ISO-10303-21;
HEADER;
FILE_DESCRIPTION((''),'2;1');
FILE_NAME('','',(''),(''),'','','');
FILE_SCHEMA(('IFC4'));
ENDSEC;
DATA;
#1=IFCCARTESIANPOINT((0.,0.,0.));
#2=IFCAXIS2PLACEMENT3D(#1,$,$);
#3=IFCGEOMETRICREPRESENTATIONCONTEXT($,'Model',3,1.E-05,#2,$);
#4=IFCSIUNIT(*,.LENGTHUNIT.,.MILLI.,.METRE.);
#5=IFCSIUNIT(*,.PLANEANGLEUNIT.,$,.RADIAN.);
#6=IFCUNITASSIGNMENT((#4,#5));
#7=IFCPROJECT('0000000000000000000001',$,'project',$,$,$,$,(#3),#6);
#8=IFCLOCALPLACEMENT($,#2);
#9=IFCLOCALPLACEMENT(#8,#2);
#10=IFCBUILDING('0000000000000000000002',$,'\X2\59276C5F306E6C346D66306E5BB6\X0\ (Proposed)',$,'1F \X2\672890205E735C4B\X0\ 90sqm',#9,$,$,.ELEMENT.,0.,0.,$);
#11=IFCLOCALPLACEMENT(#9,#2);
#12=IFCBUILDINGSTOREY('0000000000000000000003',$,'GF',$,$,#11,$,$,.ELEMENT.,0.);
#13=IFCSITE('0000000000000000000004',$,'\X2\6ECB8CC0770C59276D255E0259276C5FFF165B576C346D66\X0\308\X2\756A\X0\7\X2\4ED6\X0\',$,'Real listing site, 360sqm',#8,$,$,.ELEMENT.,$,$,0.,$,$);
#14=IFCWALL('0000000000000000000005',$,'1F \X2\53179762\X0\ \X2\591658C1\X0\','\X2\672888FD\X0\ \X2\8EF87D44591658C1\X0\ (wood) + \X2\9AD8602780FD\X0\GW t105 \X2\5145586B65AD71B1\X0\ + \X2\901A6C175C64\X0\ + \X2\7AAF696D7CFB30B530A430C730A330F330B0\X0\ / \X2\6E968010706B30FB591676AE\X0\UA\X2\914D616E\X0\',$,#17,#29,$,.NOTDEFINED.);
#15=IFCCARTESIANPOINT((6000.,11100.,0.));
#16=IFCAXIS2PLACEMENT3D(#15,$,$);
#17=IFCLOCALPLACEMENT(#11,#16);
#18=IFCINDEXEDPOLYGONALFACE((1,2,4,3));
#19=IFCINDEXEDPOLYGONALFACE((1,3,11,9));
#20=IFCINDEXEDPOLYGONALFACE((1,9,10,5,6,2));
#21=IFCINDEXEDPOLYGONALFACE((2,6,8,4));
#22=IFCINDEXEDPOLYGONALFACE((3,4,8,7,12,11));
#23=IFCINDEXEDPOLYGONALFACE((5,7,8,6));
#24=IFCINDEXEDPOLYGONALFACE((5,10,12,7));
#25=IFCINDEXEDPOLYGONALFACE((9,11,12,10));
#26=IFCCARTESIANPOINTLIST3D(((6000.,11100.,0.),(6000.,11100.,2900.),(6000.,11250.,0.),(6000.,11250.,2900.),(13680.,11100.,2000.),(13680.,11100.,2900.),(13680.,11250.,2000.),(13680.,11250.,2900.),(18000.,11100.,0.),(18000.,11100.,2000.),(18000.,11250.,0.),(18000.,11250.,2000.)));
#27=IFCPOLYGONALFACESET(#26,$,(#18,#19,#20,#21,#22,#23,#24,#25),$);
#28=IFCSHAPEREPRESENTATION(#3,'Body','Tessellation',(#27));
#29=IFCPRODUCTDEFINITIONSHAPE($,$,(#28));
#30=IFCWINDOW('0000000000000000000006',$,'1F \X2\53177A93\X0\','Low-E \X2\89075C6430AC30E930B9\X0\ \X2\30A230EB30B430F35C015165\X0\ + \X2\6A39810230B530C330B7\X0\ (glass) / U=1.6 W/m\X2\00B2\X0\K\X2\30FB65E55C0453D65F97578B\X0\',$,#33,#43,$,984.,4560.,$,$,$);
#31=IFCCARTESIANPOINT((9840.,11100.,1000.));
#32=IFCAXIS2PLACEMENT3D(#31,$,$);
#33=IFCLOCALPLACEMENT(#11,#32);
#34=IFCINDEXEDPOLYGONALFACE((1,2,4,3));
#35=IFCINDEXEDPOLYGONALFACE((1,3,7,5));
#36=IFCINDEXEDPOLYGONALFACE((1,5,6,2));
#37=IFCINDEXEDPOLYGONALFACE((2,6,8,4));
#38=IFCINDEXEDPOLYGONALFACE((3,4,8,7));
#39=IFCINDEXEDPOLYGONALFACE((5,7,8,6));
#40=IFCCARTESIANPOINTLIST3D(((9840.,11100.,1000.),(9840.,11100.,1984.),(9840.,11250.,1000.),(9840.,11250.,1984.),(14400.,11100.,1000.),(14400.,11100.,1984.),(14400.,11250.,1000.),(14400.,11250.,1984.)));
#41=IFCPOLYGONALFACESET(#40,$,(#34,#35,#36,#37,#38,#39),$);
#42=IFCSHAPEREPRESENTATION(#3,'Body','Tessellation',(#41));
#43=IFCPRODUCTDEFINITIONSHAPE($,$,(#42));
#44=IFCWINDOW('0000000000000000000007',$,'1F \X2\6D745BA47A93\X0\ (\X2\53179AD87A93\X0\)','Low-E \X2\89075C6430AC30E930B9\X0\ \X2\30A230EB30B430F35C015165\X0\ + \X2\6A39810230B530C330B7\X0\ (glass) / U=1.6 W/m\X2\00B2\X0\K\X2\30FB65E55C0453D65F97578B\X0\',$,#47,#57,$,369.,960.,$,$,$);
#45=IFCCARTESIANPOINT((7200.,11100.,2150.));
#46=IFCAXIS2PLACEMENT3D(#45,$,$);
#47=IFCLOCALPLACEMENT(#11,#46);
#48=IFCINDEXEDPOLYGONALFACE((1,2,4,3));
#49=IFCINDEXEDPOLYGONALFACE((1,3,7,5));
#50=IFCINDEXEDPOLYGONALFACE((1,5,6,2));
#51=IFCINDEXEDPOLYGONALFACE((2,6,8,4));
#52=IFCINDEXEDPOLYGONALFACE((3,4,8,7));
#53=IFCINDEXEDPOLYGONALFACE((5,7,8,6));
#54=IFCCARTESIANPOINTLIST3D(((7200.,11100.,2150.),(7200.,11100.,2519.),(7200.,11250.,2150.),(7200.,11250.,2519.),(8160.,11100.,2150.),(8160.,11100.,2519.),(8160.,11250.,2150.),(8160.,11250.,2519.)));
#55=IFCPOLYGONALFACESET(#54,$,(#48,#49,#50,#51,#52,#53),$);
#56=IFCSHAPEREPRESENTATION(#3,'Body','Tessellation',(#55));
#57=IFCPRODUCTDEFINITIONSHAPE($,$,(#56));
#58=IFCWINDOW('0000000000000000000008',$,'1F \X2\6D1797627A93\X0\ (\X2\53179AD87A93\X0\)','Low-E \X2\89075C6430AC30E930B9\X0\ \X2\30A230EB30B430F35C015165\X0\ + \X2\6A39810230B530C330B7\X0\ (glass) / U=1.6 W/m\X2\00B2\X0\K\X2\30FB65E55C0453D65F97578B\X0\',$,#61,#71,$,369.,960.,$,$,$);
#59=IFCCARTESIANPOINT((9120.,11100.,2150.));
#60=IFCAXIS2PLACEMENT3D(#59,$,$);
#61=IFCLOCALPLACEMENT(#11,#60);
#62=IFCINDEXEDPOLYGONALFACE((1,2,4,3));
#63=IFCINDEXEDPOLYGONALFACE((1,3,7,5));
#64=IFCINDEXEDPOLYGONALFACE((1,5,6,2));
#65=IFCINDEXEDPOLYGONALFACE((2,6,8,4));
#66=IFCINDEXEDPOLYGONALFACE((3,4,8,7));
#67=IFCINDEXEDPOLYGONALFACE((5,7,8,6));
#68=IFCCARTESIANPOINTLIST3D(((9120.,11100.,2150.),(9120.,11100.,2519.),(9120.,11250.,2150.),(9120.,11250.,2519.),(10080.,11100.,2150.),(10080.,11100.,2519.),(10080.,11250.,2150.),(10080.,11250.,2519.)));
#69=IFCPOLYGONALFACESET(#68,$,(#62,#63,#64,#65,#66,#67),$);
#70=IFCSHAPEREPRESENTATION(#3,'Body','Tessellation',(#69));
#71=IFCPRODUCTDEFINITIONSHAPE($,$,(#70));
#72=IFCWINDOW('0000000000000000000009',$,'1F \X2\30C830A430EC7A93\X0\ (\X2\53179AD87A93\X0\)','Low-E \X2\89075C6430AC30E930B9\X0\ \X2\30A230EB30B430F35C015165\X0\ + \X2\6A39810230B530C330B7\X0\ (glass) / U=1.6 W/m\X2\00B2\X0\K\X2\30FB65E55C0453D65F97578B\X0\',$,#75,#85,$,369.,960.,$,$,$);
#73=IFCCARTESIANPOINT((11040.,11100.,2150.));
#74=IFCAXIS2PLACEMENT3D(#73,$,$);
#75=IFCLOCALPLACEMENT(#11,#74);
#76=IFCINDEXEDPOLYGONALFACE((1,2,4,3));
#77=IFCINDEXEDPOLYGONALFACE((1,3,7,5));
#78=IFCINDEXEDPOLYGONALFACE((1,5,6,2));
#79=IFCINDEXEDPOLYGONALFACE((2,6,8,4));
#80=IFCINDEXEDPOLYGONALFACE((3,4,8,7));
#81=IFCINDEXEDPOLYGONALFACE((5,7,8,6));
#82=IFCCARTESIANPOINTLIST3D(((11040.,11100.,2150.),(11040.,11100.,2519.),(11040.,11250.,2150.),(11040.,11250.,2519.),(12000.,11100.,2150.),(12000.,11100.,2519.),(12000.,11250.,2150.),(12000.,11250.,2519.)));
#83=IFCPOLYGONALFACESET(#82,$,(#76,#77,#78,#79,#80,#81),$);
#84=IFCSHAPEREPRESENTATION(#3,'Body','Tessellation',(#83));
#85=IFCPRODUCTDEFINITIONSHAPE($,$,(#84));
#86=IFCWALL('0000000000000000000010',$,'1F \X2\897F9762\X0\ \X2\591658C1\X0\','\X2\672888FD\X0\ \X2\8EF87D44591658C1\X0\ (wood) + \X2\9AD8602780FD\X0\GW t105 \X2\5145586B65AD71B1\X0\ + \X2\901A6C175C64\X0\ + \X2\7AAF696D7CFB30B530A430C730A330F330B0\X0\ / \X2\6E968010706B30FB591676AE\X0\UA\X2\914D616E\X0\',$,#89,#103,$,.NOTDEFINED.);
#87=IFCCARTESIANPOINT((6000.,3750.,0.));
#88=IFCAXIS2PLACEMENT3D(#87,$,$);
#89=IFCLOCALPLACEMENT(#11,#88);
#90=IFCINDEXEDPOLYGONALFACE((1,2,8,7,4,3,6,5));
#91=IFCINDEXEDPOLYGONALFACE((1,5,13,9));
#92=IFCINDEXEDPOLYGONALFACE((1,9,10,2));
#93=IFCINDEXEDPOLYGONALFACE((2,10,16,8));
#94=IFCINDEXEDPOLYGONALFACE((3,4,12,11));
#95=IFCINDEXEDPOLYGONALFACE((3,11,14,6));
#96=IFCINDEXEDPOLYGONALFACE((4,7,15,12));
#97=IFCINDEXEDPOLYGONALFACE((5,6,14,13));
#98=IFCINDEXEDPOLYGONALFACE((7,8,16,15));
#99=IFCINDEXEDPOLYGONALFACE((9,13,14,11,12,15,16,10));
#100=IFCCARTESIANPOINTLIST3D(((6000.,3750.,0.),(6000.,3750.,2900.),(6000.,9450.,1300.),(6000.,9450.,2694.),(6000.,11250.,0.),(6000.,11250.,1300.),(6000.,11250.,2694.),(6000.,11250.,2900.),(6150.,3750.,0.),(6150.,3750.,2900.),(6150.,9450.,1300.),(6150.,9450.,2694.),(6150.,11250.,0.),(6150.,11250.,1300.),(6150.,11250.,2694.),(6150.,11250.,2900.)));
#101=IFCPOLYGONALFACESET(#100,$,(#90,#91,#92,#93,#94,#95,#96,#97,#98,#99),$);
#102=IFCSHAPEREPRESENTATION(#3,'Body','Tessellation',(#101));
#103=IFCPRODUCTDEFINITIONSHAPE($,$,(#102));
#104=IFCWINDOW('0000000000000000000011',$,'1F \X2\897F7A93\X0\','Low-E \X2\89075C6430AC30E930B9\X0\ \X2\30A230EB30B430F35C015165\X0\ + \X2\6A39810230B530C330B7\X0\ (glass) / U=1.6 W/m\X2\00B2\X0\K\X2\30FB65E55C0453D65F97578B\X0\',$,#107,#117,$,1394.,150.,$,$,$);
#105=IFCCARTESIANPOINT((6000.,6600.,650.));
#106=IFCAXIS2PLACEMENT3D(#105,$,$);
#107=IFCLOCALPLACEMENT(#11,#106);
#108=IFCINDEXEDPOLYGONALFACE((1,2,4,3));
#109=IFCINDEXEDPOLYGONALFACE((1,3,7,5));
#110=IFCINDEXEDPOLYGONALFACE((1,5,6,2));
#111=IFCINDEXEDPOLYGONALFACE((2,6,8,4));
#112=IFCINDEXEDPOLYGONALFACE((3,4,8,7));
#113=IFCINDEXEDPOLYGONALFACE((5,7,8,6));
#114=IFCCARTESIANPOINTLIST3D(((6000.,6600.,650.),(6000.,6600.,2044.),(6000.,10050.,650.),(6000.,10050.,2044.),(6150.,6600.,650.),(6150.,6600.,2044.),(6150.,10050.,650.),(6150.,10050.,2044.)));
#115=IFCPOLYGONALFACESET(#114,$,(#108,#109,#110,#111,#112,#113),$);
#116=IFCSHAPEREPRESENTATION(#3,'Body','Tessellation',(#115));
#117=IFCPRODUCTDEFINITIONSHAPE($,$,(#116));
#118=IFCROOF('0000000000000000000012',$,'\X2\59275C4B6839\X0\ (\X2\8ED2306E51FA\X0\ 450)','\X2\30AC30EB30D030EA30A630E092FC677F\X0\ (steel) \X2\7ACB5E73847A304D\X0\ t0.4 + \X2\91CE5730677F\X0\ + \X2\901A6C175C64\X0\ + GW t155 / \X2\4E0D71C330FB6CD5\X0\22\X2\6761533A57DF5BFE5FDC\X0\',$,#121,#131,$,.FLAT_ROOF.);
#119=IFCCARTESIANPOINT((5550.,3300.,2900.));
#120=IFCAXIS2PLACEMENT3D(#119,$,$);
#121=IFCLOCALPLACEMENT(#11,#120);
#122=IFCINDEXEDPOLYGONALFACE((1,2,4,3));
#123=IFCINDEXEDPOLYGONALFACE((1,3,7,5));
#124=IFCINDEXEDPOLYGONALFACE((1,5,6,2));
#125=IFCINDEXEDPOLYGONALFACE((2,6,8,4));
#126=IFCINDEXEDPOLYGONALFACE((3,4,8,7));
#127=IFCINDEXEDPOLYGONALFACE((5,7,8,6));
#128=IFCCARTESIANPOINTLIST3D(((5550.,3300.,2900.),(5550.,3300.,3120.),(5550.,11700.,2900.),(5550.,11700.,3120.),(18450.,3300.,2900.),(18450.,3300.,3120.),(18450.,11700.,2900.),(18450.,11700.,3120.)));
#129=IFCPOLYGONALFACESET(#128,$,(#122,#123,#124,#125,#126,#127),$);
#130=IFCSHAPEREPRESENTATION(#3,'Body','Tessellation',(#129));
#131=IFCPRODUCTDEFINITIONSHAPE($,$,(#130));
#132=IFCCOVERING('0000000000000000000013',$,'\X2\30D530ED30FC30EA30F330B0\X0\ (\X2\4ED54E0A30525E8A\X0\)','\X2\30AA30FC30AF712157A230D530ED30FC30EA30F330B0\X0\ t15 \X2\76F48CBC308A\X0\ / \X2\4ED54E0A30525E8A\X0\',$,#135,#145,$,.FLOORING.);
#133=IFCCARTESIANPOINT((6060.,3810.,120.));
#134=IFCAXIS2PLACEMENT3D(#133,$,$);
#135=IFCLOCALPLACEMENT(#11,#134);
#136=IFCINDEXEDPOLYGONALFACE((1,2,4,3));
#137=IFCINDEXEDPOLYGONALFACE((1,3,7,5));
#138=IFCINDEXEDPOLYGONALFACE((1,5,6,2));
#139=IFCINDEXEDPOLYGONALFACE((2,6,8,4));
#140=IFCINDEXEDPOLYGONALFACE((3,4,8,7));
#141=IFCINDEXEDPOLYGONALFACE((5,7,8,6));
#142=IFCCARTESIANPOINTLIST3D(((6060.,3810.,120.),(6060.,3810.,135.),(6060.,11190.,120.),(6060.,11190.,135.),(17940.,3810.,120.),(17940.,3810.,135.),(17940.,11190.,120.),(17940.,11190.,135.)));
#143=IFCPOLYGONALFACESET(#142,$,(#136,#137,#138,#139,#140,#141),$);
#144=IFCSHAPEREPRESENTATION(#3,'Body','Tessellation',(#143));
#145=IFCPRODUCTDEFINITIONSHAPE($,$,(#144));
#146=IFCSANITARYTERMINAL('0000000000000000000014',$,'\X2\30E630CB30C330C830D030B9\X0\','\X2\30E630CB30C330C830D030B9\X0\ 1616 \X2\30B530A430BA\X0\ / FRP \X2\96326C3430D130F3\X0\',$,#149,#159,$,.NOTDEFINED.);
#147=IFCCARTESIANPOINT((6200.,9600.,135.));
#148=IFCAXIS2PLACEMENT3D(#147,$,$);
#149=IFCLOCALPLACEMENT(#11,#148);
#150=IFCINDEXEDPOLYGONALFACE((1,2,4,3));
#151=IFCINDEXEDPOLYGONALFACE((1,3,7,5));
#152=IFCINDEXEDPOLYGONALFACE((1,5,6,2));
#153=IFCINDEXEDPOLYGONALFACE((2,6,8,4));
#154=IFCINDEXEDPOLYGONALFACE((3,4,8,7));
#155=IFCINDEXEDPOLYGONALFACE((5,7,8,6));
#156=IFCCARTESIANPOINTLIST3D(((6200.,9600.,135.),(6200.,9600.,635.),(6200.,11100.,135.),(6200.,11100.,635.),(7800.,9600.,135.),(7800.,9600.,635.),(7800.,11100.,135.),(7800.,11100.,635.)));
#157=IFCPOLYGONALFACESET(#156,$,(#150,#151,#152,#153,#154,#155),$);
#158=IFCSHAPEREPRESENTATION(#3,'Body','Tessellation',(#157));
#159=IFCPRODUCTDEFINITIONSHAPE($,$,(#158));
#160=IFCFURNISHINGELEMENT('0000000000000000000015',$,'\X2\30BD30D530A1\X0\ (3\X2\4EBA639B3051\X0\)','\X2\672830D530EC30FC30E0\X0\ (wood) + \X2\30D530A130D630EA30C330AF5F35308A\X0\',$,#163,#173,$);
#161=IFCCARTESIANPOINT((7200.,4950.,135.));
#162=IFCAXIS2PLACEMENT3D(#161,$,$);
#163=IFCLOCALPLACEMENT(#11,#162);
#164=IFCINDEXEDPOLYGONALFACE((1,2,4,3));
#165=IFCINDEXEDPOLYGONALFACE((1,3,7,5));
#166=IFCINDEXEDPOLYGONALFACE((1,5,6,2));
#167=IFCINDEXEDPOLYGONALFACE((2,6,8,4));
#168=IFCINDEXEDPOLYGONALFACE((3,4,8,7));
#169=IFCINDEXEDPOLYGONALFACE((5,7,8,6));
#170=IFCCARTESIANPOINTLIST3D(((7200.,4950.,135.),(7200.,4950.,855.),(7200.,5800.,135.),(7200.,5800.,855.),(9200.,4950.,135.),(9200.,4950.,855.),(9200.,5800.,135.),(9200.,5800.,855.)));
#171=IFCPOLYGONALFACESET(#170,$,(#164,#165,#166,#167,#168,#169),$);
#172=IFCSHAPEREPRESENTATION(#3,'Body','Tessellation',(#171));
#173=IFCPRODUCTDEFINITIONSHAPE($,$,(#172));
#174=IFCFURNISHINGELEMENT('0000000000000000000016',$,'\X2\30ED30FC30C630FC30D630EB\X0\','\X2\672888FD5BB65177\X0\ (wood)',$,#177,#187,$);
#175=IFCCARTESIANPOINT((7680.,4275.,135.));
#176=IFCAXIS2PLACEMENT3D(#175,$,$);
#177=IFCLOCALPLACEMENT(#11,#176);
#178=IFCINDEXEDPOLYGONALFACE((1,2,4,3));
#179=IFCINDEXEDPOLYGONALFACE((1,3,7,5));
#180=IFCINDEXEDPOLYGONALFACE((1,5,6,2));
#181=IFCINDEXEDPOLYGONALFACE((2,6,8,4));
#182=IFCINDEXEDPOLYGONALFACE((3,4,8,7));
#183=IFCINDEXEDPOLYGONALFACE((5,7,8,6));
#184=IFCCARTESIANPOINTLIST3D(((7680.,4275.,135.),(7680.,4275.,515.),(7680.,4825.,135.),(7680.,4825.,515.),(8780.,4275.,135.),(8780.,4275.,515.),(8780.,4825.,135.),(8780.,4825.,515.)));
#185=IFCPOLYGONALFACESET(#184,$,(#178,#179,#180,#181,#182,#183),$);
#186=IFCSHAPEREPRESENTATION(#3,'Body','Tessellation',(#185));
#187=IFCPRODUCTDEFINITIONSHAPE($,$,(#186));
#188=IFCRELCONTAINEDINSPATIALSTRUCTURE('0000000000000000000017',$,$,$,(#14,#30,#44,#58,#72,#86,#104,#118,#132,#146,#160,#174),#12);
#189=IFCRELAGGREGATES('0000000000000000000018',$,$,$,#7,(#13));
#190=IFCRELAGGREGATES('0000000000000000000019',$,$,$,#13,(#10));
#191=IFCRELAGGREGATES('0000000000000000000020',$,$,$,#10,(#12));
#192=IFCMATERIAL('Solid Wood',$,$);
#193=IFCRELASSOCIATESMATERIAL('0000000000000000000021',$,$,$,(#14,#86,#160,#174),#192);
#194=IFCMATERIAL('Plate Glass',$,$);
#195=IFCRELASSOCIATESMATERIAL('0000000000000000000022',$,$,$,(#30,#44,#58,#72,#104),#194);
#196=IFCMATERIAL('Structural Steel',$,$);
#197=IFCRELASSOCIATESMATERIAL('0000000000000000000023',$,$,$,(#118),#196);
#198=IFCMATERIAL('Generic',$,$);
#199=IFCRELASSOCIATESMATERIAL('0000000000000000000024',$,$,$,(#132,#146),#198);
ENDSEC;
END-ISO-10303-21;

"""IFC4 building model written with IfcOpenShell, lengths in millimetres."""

from ifc_helpers import new_model, si_unit, frame, frame_2d, origin, place, context, project, spatial, rectangle, extrude, material, element, fill, save


model = new_model("IFC4")

# Units and contexts
model_context = context("Model", 3, precision=1e-05, world=origin())
ifc_project = project(units=[si_unit("LENGTHUNIT", "METRE", prefix="MILLI"), si_unit("PLANEANGLEUNIT", "RADIAN")], contexts=[model_context])

# Site, building, storey
site_placement = place(None, origin())
site = spatial("IfcSite", under=ifc_project, at=site_placement, Name="滋賀県大津市大江６字水浦308番7他", ObjectType="Real listing site, 360sqm", CompositionType="ELEMENT", RefElevation=0.0)
building_placement = place(site_placement, origin())
building = spatial("IfcBuilding", under=site, at=building_placement, Name="大江の水浦の家 (Proposed)", ObjectType="1F 木造平屋 90sqm", CompositionType="ELEMENT", ElevationOfRefHeight=0.0, ElevationOfTerrain=0.0)
storey_placement = place(building_placement, origin())
storey = spatial("IfcBuildingStorey", under=building, at=storey_placement, Name="GF", CompositionType="ELEMENT", Elevation=0.0)

# Shared definitions
ifc_material_1 = material(Name="Solid Wood")

# Shared definitions
ifc_material_2 = material(Name="Plate Glass")

# Wall, openings, windows
wall_1_placement = place(storey_placement, frame((6000.0, 11100.0, 0.0)))
wall_1 = element("IfcWall", 1, at=wall_1_placement, inside=storey, material=ifc_material_1, Name="1F 北面 外壁", Description="木製 軸組外壁 (wood) + 高性能GW t105 充填断熱 + 通気層 + 窯業系サイディング / 準耐火・外皮UA配慮", PredefinedType="NOTDEFINED", context=model_context, shape_type="SweptSolid", body=[
    extrude(rectangle(XDim=12000.0, YDim=150.0, at=frame_2d((6000.0, 75.0))), frame((6000.0, 11100.0, 0.0)), (0.0, 0.0, 1.0), 2900.0),
])
opening_1_placement = place(storey_placement, frame((9840.0, 11100.0, 1000.0)))
opening_1 = element("IfcOpeningElement", 2, at=opening_1_placement, cuts=wall_1, PredefinedType="NOTDEFINED", context=model_context, shape_type="SweptSolid", body=[
    extrude(rectangle(XDim=4560.0, YDim=150.0, at=frame_2d((2280.0, 75.0))), frame((9840.0, 11100.0, 1000.0)), (0.0, 0.0, 1.0), 984.0),
])
opening_2_placement = place(storey_placement, frame((7200.0, 11100.0, 2150.0)))
opening_2 = element("IfcOpeningElement", 3, at=opening_2_placement, cuts=wall_1, PredefinedType="NOTDEFINED", context=model_context, shape_type="SweptSolid", body=[
    extrude(rectangle(XDim=960.0, YDim=150.0, at=frame_2d((480.0, 75.0))), frame((7200.0, 11100.0, 2150.0)), (0.0, 0.0, 1.0), 369.0),
])
opening_3_placement = place(storey_placement, frame((9120.0, 11100.0, 2150.0)))
opening_3 = element("IfcOpeningElement", 4, at=opening_3_placement, cuts=wall_1, PredefinedType="NOTDEFINED", context=model_context, shape_type="SweptSolid", body=[
    extrude(rectangle(XDim=960.0, YDim=150.0, at=frame_2d((480.0, 75.0))), frame((9120.0, 11100.0, 2150.0)), (0.0, 0.0, 1.0), 369.0),
])
opening_4_placement = place(storey_placement, frame((11040.0, 11100.0, 2150.0)))
opening_4 = element("IfcOpeningElement", 5, at=opening_4_placement, cuts=wall_1, PredefinedType="NOTDEFINED", context=model_context, shape_type="SweptSolid", body=[
    extrude(rectangle(XDim=960.0, YDim=150.0, at=frame_2d((480.0, 75.0))), frame((11040.0, 11100.0, 2150.0)), (0.0, 0.0, 1.0), 369.0),
])
window_1_placement = place(storey_placement, frame((9840.0, 11100.0, 1000.0)))
window_1 = element("IfcWindow", 6, at=window_1_placement, inside=storey, material=ifc_material_2, Name="1F 北窓", Description="Low-E 複層ガラス アルゴン封入 + 樹脂サッシ (glass) / U=1.6 W/m²K・日射取得型", OverallHeight=984.0, OverallWidth=4560.0, context=model_context, shape_type="SweptSolid", body=[
    extrude(rectangle(XDim=4560.0, YDim=150.0, at=frame_2d((2280.0, 75.0))), frame((9840.0, 11100.0, 1000.0)), (0.0, 0.0, 1.0), 984.0),
])
fill(opening_1, window_1)
window_2_placement = place(storey_placement, frame((7200.0, 11100.0, 2150.0)))
window_2 = element("IfcWindow", 7, at=window_2_placement, inside=storey, material=ifc_material_2, Name="1F 浴室窓 (北高窓)", Description="Low-E 複層ガラス アルゴン封入 + 樹脂サッシ (glass) / U=1.6 W/m²K・日射取得型", OverallHeight=369.0, OverallWidth=960.0, context=model_context, shape_type="SweptSolid", body=[
    extrude(rectangle(XDim=960.0, YDim=150.0, at=frame_2d((480.0, 75.0))), frame((7200.0, 11100.0, 2150.0)), (0.0, 0.0, 1.0), 369.0),
])
fill(opening_2, window_2)
window_3_placement = place(storey_placement, frame((9120.0, 11100.0, 2150.0)))
window_3 = element("IfcWindow", 8, at=window_3_placement, inside=storey, material=ifc_material_2, Name="1F 洗面窓 (北高窓)", Description="Low-E 複層ガラス アルゴン封入 + 樹脂サッシ (glass) / U=1.6 W/m²K・日射取得型", OverallHeight=369.0, OverallWidth=960.0, context=model_context, shape_type="SweptSolid", body=[
    extrude(rectangle(XDim=960.0, YDim=150.0, at=frame_2d((480.0, 75.0))), frame((9120.0, 11100.0, 2150.0)), (0.0, 0.0, 1.0), 369.0),
])
fill(opening_3, window_3)
window_4_placement = place(storey_placement, frame((11040.0, 11100.0, 2150.0)))
window_4 = element("IfcWindow", 9, at=window_4_placement, inside=storey, material=ifc_material_2, Name="1F トイレ窓 (北高窓)", Description="Low-E 複層ガラス アルゴン封入 + 樹脂サッシ (glass) / U=1.6 W/m²K・日射取得型", OverallHeight=369.0, OverallWidth=960.0, context=model_context, shape_type="SweptSolid", body=[
    extrude(rectangle(XDim=960.0, YDim=150.0, at=frame_2d((480.0, 75.0))), frame((11040.0, 11100.0, 2150.0)), (0.0, 0.0, 1.0), 369.0),
])
fill(opening_4, window_4)

# Wall, opening, window
wall_2_placement = place(storey_placement, frame((6000.0, 3750.0, 0.0)))
wall_2 = element("IfcWall", 10, at=wall_2_placement, inside=storey, material=ifc_material_1, Name="1F 西面 外壁", Description="木製 軸組外壁 (wood) + 高性能GW t105 充填断熱 + 通気層 + 窯業系サイディング / 準耐火・外皮UA配慮", PredefinedType="NOTDEFINED", context=model_context, shape_type="SweptSolid", body=[
    extrude(rectangle(XDim=150.0, YDim=7500.0, at=frame_2d((75.0, 3750.0))), frame((6000.0, 3750.0, 0.0)), (0.0, 0.0, 1.0), 2900.0),
])
opening_5_placement = place(storey_placement, frame((6000.0, 6600.0, 650.0)))
opening_5 = element("IfcOpeningElement", 11, at=opening_5_placement, cuts=wall_2, PredefinedType="NOTDEFINED", context=model_context, shape_type="SweptSolid", body=[
    extrude(rectangle(XDim=150.0, YDim=3450.0, at=frame_2d((75.0, 1725.0))), frame((6000.0, 6600.0, 650.0)), (0.0, 0.0, 1.0), 1394.0),
])
window_5_placement = place(storey_placement, frame((6000.0, 6600.0, 650.0)))
window_5 = element("IfcWindow", 12, at=window_5_placement, inside=storey, material=ifc_material_2, Name="1F 西窓", Description="Low-E 複層ガラス アルゴン封入 + 樹脂サッシ (glass) / U=1.6 W/m²K・日射取得型", OverallHeight=1394.0, OverallWidth=150.0, context=model_context, shape_type="SweptSolid", body=[
    extrude(rectangle(XDim=150.0, YDim=3450.0, at=frame_2d((75.0, 1725.0))), frame((6000.0, 6600.0, 650.0)), (0.0, 0.0, 1.0), 1394.0),
])
fill(opening_5, window_5)

# Roof
ifc_material_3 = material(Name="Structural Steel")
roof_placement = place(storey_placement, frame((5550.0, 3300.0, 2900.0)))
element("IfcRoof", 13, at=roof_placement, inside=storey, material=ifc_material_3, Name="大屋根 (軒の出 450)", Description="ガルバリウム鋼板 (steel) 立平葺き t0.4 + 野地板 + 通気層 + GW t155 / 不燃・法22条区域対応", PredefinedType="FLAT_ROOF", context=model_context, shape_type="SweptSolid", body=[
    extrude(rectangle(XDim=12900.0, YDim=8400.0, at=frame_2d((6450.0, 4200.0))), frame((5550.0, 3300.0, 2900.0)), (0.0, 0.0, 1.0), 220.0),
])

# Covering
ifc_material_4 = material(Name="Generic")
covering_placement = place(storey_placement, frame((6060.0, 3810.0, 120.0)))
element("IfcCovering", 14, at=covering_placement, inside=storey, material=ifc_material_4, Name="フローリング (仕上げ床)", Description="オーク無垢フローリング t15 直貼り / 仕上げ床", PredefinedType="FLOORING", context=model_context, shape_type="SweptSolid", body=[
    extrude(rectangle(XDim=11880.0, YDim=7380.0, at=frame_2d((5940.0, 3690.0))), frame((6060.0, 3810.0, 120.0)), (0.0, 0.0, 1.0), 15.0),
])

# Sanitary terminal
sanitary_terminal_placement = place(storey_placement, frame((6200.0, 9600.0, 135.0)))
element("IfcSanitaryTerminal", 15, at=sanitary_terminal_placement, inside=storey, material=ifc_material_4, Name="ユニットバス", Description="ユニットバス 1616 サイズ / FRP 防水パン", PredefinedType="NOTDEFINED", context=model_context, shape_type="SweptSolid", body=[
    extrude(rectangle(XDim=1600.0, YDim=1500.0, at=frame_2d((800.0, 750.0))), frame((6200.0, 9600.0, 135.0)), (0.0, 0.0, 1.0), 500.0),
])

# Furnishing elements
furnishing_1_placement = place(storey_placement, frame((7200.0, 4950.0, 135.0)))
element("IfcFurnishingElement", 16, at=furnishing_1_placement, inside=storey, material=ifc_material_1, Name="ソファ (3人掛け)", Description="木フレーム (wood) + ファブリック張り", context=model_context, shape_type="SweptSolid", body=[
    extrude(rectangle(XDim=2000.0, YDim=850.0, at=frame_2d((1000.0, 425.0))), frame((7200.0, 4950.0, 135.0)), (0.0, 0.0, 1.0), 720.0),
])
furnishing_2_placement = place(storey_placement, frame((7680.0, 4275.0, 135.0)))
element("IfcFurnishingElement", 17, at=furnishing_2_placement, inside=storey, material=ifc_material_1, Name="ローテーブル", Description="木製家具 (wood)", context=model_context, shape_type="SweptSolid", body=[
    extrude(rectangle(XDim=1100.0, YDim=550.0, at=frame_2d((550.0, 275.0))), frame((7680.0, 4275.0, 135.0)), (0.0, 0.0, 1.0), 380.0),
])

save(model, "model.ifc")
